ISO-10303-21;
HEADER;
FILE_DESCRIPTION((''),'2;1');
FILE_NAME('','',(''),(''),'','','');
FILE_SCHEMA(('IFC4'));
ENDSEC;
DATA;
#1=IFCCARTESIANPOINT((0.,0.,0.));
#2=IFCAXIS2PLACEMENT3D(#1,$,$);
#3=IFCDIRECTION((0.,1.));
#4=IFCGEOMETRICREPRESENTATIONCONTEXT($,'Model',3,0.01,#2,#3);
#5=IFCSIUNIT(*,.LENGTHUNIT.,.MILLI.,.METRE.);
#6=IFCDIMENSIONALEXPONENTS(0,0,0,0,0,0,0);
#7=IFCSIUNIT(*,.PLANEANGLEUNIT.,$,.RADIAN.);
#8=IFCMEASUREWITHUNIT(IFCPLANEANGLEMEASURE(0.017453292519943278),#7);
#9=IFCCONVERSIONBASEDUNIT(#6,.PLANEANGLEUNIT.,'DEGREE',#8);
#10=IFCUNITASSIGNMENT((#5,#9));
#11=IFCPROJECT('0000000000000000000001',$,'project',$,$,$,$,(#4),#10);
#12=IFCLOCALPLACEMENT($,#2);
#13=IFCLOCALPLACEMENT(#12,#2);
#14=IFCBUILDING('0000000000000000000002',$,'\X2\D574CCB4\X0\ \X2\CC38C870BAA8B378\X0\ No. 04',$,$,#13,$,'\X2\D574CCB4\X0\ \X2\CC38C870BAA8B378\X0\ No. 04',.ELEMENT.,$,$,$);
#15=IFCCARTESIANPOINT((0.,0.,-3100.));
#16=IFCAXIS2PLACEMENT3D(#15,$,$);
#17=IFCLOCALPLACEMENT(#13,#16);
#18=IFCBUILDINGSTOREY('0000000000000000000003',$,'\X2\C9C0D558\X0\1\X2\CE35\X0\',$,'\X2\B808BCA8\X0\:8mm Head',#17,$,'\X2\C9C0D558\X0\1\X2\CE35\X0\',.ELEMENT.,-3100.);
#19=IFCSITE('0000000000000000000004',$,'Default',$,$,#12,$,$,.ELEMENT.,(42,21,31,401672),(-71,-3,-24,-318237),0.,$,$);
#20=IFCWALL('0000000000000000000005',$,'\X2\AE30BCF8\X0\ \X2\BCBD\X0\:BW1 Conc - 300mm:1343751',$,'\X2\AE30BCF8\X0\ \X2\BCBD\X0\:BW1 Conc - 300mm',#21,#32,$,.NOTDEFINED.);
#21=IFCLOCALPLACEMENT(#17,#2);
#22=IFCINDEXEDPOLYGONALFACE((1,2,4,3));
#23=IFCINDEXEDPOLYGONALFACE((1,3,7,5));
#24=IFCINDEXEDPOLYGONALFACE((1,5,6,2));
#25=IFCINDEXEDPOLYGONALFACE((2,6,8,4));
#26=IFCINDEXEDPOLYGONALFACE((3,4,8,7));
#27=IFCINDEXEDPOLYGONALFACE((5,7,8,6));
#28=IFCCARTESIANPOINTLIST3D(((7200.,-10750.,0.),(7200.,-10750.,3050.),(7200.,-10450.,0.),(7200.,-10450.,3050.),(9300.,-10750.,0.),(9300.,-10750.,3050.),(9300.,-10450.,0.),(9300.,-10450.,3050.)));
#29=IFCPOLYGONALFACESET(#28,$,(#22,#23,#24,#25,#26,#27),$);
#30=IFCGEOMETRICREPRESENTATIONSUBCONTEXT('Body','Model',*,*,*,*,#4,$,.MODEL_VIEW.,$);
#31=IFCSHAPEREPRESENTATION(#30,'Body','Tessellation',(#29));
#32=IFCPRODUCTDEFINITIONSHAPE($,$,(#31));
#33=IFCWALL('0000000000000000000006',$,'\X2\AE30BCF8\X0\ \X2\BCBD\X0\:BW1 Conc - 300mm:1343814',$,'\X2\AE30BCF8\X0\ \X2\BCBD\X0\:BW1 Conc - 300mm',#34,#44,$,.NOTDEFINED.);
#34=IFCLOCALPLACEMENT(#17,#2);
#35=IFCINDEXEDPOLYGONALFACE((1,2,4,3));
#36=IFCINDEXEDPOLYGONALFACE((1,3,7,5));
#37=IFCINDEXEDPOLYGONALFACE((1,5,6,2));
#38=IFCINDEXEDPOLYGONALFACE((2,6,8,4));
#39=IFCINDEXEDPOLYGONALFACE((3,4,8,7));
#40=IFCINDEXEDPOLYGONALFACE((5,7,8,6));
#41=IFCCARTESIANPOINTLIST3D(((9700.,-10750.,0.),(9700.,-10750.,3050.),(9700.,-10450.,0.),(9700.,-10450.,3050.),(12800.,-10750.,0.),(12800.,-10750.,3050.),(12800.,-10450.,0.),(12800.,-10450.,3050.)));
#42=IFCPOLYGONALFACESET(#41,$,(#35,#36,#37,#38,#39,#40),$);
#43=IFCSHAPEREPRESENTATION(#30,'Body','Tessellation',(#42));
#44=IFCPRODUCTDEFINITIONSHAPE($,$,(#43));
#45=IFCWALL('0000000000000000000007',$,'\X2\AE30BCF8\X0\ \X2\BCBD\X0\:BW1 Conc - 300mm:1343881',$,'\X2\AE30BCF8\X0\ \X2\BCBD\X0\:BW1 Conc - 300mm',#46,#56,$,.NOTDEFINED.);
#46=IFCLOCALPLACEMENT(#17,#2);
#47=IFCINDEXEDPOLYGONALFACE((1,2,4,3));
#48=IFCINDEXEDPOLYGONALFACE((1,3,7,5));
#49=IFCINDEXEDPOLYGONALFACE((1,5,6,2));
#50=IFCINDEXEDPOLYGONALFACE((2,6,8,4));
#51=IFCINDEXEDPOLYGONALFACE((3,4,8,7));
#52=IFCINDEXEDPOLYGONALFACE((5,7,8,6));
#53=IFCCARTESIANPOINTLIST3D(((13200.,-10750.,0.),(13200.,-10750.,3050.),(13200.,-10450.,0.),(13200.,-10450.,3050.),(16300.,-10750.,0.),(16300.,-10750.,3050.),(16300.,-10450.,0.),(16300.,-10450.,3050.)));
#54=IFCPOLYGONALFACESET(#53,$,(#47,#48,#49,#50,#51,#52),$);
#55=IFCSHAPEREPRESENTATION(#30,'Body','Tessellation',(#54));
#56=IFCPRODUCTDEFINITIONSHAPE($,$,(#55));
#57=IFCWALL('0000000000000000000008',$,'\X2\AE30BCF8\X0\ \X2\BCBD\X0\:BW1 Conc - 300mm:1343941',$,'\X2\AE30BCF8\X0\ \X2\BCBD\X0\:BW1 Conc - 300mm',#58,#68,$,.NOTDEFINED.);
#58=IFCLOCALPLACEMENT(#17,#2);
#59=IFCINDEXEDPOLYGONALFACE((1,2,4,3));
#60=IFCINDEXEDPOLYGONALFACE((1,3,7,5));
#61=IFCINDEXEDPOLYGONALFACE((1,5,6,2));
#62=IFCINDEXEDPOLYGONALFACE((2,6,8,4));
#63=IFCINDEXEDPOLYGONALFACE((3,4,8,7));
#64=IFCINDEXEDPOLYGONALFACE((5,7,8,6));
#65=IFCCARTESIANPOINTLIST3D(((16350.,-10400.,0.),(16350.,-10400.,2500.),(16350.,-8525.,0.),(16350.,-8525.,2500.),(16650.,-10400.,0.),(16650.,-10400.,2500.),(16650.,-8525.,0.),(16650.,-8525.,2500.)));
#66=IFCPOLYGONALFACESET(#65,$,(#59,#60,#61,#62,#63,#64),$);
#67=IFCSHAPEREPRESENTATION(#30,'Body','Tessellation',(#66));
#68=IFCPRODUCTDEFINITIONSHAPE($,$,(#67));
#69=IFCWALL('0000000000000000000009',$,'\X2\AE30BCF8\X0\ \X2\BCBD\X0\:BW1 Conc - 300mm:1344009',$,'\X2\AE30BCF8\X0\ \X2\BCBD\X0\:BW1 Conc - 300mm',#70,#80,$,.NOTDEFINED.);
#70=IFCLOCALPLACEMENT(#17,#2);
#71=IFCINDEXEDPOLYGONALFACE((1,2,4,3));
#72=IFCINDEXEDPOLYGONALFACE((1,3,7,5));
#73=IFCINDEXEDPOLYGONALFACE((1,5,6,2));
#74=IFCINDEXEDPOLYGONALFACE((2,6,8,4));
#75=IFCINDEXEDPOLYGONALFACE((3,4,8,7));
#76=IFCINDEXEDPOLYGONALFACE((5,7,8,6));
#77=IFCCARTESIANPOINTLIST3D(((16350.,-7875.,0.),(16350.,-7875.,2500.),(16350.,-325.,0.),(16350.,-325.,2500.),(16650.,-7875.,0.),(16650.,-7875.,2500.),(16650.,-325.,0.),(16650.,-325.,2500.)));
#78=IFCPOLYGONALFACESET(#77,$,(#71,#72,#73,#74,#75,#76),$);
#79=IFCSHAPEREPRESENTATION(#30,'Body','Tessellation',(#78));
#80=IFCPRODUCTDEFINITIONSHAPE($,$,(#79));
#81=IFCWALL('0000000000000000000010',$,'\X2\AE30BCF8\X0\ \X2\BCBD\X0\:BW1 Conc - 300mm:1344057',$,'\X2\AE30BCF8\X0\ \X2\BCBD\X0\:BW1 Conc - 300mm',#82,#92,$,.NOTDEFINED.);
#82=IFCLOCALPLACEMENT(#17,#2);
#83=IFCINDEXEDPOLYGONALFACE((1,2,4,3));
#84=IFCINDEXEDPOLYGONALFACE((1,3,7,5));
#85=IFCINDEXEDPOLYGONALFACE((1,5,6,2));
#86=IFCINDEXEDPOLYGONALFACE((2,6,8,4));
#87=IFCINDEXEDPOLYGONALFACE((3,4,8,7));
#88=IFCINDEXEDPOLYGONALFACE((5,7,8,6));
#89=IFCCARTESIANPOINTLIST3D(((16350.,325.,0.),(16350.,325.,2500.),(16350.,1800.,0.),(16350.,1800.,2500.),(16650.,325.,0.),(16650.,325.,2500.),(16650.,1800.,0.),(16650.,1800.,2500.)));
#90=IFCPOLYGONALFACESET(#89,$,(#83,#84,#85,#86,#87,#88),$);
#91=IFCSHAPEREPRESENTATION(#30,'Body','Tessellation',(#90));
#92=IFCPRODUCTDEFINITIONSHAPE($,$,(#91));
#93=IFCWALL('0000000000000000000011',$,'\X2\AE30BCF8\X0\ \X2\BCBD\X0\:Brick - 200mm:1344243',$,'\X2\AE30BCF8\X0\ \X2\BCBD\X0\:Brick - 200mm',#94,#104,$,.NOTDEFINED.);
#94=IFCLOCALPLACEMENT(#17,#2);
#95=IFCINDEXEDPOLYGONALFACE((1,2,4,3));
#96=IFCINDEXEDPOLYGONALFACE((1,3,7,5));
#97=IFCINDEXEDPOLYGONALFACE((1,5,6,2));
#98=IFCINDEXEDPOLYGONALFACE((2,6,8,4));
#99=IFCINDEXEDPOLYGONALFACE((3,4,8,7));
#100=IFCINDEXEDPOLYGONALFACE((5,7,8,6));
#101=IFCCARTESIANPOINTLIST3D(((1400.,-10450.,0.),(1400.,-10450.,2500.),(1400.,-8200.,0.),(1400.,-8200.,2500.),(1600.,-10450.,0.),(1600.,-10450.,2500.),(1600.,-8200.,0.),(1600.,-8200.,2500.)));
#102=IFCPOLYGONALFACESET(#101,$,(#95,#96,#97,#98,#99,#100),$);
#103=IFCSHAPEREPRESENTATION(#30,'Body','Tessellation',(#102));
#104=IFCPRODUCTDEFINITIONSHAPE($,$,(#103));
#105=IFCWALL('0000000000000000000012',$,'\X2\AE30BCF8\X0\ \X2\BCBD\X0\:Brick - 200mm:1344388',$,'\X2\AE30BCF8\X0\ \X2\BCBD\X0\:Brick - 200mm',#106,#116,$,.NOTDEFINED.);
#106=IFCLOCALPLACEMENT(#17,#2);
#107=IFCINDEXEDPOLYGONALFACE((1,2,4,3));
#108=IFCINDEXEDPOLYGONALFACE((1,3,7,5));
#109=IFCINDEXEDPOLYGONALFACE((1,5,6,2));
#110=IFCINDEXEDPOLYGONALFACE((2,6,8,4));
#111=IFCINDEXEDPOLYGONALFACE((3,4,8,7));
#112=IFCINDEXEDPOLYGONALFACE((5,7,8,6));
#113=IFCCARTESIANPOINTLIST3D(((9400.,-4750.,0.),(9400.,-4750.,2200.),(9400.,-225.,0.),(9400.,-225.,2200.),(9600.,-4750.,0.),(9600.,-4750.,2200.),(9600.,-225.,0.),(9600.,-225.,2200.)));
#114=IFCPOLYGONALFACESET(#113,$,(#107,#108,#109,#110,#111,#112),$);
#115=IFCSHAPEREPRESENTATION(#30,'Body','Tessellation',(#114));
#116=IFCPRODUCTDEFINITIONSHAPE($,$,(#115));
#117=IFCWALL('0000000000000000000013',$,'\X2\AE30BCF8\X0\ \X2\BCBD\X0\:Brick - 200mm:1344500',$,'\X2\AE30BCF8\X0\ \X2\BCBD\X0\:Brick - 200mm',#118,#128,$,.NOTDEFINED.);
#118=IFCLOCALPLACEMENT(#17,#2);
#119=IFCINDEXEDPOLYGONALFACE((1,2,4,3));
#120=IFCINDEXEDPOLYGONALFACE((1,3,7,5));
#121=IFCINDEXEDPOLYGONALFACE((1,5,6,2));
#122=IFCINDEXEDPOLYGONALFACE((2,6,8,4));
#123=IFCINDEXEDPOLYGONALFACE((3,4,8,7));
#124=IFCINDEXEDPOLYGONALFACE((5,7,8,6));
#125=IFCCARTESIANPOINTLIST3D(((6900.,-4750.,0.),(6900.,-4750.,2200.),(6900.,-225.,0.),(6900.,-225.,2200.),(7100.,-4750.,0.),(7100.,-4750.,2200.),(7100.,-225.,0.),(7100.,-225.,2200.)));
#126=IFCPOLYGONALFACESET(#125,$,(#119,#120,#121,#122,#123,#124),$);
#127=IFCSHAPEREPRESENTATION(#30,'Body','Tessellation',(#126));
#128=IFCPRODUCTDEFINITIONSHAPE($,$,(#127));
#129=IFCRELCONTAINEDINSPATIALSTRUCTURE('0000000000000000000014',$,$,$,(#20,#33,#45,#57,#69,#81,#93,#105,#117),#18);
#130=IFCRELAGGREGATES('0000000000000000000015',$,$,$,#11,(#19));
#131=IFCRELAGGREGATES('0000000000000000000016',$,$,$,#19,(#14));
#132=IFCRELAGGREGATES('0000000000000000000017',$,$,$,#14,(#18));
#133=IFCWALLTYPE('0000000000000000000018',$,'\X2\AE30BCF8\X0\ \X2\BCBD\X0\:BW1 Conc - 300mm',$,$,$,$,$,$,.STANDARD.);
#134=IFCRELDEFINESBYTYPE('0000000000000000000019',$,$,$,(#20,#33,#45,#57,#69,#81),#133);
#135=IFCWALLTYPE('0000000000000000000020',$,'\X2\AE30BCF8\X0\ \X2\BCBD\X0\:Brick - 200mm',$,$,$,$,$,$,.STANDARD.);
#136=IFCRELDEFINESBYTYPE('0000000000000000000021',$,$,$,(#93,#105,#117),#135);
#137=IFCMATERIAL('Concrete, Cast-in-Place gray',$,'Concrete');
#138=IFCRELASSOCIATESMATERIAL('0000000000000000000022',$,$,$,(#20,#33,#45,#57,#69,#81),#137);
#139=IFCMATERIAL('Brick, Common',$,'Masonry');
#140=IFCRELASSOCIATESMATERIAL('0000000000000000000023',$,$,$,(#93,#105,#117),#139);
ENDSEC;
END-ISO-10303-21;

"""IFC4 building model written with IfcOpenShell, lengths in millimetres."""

from ifc_helpers import new_model, entity, si_unit, converted_unit, direction, frame, origin, place, context, subcontext, project, spatial, indexed_curve, outline, extrude, material, type_object, element, save


model = new_model("IFC4")

# Units and contexts
model_context = context("Model", 3, precision=0.01, world=origin(), true_north=direction((0.0, 1.0)))
body_context = subcontext(model_context, "Body", "Model", "MODEL_VIEW")
ifc_project = project(units=[si_unit("LENGTHUNIT", "METRE", prefix="MILLI"), converted_unit("PLANEANGLEUNIT", "DEGREE", entity("IfcPlaneAngleMeasure", 0.017453292519943278), si_unit("PLANEANGLEUNIT", "RADIAN"), dimensions=[0, 0, 0, 0, 0, 0, 0])], contexts=[model_context])

# Site, building, storey
site_placement = place(None, origin())
site = spatial("IfcSite", under=ifc_project, at=site_placement, Name="Default", CompositionType="ELEMENT", RefLatitude=(42, 21, 31, 401672), RefLongitude=(-71, -3, -24, -318237), RefElevation=0.0)
building_placement = place(site_placement, origin())
building = spatial("IfcBuilding", under=site, at=building_placement, Name="해체 참조모델 No. 04", LongName="해체 참조모델 No. 04", CompositionType="ELEMENT")
storey_placement = place(building_placement, frame((0.0, 0.0, -3100.0)))
storey = spatial("IfcBuildingStorey", under=building, at=storey_placement, Name="지하1층", ObjectType="레벨:8mm Head", LongName="지하1층", CompositionType="ELEMENT", Elevation=-3100.0)

# Shared definitions
ifc_material_1 = material(Name="Concrete, Cast-in-Place gray", Category="Concrete")

# Walls
wall_type_1 = type_object("IfcWallType", Name="기본 벽:BW1 Conc - 300mm", PredefinedType="STANDARD")
wall_1_placement = place(storey_placement, frame((7200.0, -10600.0, 0.0)))
element("IfcWall", 1, at=wall_1_placement, inside=storey, type_object=wall_type_1, material=ifc_material_1, Name="기본 벽:BW1 Conc - 300mm:1343751", ObjectType="기본 벽:BW1 Conc - 300mm", PredefinedType="NOTDEFINED", context=body_context, shape_type="SweptSolid", body=[
    extrude(outline(indexed_curve([(2100.0, 150.0), (0.0, 150.0), (0.0, -150.0), (2100.0, -150.0), (2100.0, 150.0)], self_intersect=False)), origin(), (0.0, 0.0, 1.0), 3050.0),
])
wall_2_placement = place(storey_placement, frame((9700.0, -10600.0, 0.0)))
element("IfcWall", 2, at=wall_2_placement, inside=storey, type_object=wall_type_1, material=ifc_material_1, Name="기본 벽:BW1 Conc - 300mm:1343814", ObjectType="기본 벽:BW1 Conc - 300mm", PredefinedType="NOTDEFINED", context=body_context, shape_type="SweptSolid", body=[
    extrude(outline(indexed_curve([(3100.0, 150.0), (0.0, 150.0), (0.0, -150.0), (3100.0, -150.0), (3100.0, 150.0)], self_intersect=False)), origin(), (0.0, 0.0, 1.0), 3050.0),
])
wall_3_placement = place(storey_placement, frame((13200.0, -10600.0, 0.0)))
element("IfcWall", 3, at=wall_3_placement, inside=storey, type_object=wall_type_1, material=ifc_material_1, Name="기본 벽:BW1 Conc - 300mm:1343881", ObjectType="기본 벽:BW1 Conc - 300mm", PredefinedType="NOTDEFINED", context=body_context, shape_type="SweptSolid", body=[
    extrude(outline(indexed_curve([(3100.0, 150.0), (0.0, 150.0), (0.0, -150.0), (3100.0, -150.0), (3100.0, 150.0)], self_intersect=False)), origin(), (0.0, 0.0, 1.0), 3050.0),
])
wall_4_placement = place(storey_placement, frame((16500.0, -10400.0, 0.0), z_axis=(0.0, 0.0, 1.0), x_axis=(0.0, 1.0, 0.0)))
element("IfcWall", 4, at=wall_4_placement, inside=storey, type_object=wall_type_1, material=ifc_material_1, Name="기본 벽:BW1 Conc - 300mm:1343941", ObjectType="기본 벽:BW1 Conc - 300mm", PredefinedType="NOTDEFINED", context=body_context, shape_type="SweptSolid", body=[
    extrude(outline(indexed_curve([(1875.0, 150.0), (0.0, 150.0), (0.0, -150.0), (1875.0, -150.0), (1875.0, 150.0)], self_intersect=False)), origin(), (0.0, 0.0, 1.0), 2500.0),
])
wall_5_placement = place(storey_placement, frame((16500.0, -7875.0, 0.0), z_axis=(0.0, 0.0, 1.0), x_axis=(0.0, 1.0, 0.0)))
element("IfcWall", 5, at=wall_5_placement, inside=storey, type_object=wall_type_1, material=ifc_material_1, Name="기본 벽:BW1 Conc - 300mm:1344009", ObjectType="기본 벽:BW1 Conc - 300mm", PredefinedType="NOTDEFINED", context=body_context, shape_type="SweptSolid", body=[
    extrude(outline(indexed_curve([(7550.0, 150.0), (0.0, 150.0), (0.0, -150.0), (7550.0, -150.0), (7550.0, 150.0)], self_intersect=False)), origin(), (0.0, 0.0, 1.0), 2500.0),
])
wall_6_placement = place(storey_placement, frame((16500.0, 325.0, 0.0), z_axis=(0.0, 0.0, 1.0), x_axis=(0.0, 1.0, 0.0)))
element("IfcWall", 6, at=wall_6_placement, inside=storey, type_object=wall_type_1, material=ifc_material_1, Name="기본 벽:BW1 Conc - 300mm:1344057", ObjectType="기본 벽:BW1 Conc - 300mm", PredefinedType="NOTDEFINED", context=body_context, shape_type="SweptSolid", body=[
    extrude(outline(indexed_curve([(1475.0, 150.0), (0.0, 150.0), (0.0, -150.0), (1475.0, -150.0), (1475.0, 150.0)], self_intersect=False)), origin(), (0.0, 0.0, 1.0), 2500.0),
])
ifc_material_2 = material(Name="Brick, Common", Category="Masonry")
wall_type_2 = type_object("IfcWallType", Name="기본 벽:Brick - 200mm", PredefinedType="STANDARD")
wall_7_placement = place(storey_placement, frame((1500.0, -10450.0, 0.0), z_axis=(0.0, 0.0, 1.0), x_axis=(0.0, 1.0, 0.0)))
element("IfcWall", 7, at=wall_7_placement, inside=storey, type_object=wall_type_2, material=ifc_material_2, Name="기본 벽:Brick - 200mm:1344243", ObjectType="기본 벽:Brick - 200mm", PredefinedType="NOTDEFINED", context=body_context, shape_type="SweptSolid", body=[
    extrude(outline(indexed_curve([(2250.0, 100.0), (0.0, 100.0), (0.0, -100.0), (2250.0, -100.0), (2250.0, 100.0)], self_intersect=False)), origin(), (0.0, 0.0, 1.0), 2500.0),
])
wall_8_placement = place(storey_placement, frame((9500.0, -4750.0, 0.0), z_axis=(0.0, 0.0, 1.0), x_axis=(0.0, 1.0, 0.0)))
element("IfcWall", 8, at=wall_8_placement, inside=storey, type_object=wall_type_2, material=ifc_material_2, Name="기본 벽:Brick - 200mm:1344388", ObjectType="기본 벽:Brick - 200mm", PredefinedType="NOTDEFINED", context=body_context, shape_type="SweptSolid", body=[
    extrude(outline(indexed_curve([(4525.0, 100.0), (0.0, 100.0), (0.0, -100.0), (4525.0, -100.0), (4525.0, 100.0)], self_intersect=False)), origin(), (0.0, 0.0, 1.0), 2200.0),
])
wall_9_placement = place(storey_placement, frame((7000.0, -4750.0, 0.0), z_axis=(0.0, 0.0, 1.0), x_axis=(0.0, 1.0, 0.0)))
element("IfcWall", 9, at=wall_9_placement, inside=storey, type_object=wall_type_2, material=ifc_material_2, Name="기본 벽:Brick - 200mm:1344500", ObjectType="기본 벽:Brick - 200mm", PredefinedType="NOTDEFINED", context=body_context, shape_type="SweptSolid", body=[
    extrude(outline(indexed_curve([(4525.0, 100.0), (0.0, 100.0), (0.0, -100.0), (4525.0, -100.0), (4525.0, 100.0)], self_intersect=False)), origin(), (0.0, 0.0, 1.0), 2200.0),
])

save(model, "model.ifc")
